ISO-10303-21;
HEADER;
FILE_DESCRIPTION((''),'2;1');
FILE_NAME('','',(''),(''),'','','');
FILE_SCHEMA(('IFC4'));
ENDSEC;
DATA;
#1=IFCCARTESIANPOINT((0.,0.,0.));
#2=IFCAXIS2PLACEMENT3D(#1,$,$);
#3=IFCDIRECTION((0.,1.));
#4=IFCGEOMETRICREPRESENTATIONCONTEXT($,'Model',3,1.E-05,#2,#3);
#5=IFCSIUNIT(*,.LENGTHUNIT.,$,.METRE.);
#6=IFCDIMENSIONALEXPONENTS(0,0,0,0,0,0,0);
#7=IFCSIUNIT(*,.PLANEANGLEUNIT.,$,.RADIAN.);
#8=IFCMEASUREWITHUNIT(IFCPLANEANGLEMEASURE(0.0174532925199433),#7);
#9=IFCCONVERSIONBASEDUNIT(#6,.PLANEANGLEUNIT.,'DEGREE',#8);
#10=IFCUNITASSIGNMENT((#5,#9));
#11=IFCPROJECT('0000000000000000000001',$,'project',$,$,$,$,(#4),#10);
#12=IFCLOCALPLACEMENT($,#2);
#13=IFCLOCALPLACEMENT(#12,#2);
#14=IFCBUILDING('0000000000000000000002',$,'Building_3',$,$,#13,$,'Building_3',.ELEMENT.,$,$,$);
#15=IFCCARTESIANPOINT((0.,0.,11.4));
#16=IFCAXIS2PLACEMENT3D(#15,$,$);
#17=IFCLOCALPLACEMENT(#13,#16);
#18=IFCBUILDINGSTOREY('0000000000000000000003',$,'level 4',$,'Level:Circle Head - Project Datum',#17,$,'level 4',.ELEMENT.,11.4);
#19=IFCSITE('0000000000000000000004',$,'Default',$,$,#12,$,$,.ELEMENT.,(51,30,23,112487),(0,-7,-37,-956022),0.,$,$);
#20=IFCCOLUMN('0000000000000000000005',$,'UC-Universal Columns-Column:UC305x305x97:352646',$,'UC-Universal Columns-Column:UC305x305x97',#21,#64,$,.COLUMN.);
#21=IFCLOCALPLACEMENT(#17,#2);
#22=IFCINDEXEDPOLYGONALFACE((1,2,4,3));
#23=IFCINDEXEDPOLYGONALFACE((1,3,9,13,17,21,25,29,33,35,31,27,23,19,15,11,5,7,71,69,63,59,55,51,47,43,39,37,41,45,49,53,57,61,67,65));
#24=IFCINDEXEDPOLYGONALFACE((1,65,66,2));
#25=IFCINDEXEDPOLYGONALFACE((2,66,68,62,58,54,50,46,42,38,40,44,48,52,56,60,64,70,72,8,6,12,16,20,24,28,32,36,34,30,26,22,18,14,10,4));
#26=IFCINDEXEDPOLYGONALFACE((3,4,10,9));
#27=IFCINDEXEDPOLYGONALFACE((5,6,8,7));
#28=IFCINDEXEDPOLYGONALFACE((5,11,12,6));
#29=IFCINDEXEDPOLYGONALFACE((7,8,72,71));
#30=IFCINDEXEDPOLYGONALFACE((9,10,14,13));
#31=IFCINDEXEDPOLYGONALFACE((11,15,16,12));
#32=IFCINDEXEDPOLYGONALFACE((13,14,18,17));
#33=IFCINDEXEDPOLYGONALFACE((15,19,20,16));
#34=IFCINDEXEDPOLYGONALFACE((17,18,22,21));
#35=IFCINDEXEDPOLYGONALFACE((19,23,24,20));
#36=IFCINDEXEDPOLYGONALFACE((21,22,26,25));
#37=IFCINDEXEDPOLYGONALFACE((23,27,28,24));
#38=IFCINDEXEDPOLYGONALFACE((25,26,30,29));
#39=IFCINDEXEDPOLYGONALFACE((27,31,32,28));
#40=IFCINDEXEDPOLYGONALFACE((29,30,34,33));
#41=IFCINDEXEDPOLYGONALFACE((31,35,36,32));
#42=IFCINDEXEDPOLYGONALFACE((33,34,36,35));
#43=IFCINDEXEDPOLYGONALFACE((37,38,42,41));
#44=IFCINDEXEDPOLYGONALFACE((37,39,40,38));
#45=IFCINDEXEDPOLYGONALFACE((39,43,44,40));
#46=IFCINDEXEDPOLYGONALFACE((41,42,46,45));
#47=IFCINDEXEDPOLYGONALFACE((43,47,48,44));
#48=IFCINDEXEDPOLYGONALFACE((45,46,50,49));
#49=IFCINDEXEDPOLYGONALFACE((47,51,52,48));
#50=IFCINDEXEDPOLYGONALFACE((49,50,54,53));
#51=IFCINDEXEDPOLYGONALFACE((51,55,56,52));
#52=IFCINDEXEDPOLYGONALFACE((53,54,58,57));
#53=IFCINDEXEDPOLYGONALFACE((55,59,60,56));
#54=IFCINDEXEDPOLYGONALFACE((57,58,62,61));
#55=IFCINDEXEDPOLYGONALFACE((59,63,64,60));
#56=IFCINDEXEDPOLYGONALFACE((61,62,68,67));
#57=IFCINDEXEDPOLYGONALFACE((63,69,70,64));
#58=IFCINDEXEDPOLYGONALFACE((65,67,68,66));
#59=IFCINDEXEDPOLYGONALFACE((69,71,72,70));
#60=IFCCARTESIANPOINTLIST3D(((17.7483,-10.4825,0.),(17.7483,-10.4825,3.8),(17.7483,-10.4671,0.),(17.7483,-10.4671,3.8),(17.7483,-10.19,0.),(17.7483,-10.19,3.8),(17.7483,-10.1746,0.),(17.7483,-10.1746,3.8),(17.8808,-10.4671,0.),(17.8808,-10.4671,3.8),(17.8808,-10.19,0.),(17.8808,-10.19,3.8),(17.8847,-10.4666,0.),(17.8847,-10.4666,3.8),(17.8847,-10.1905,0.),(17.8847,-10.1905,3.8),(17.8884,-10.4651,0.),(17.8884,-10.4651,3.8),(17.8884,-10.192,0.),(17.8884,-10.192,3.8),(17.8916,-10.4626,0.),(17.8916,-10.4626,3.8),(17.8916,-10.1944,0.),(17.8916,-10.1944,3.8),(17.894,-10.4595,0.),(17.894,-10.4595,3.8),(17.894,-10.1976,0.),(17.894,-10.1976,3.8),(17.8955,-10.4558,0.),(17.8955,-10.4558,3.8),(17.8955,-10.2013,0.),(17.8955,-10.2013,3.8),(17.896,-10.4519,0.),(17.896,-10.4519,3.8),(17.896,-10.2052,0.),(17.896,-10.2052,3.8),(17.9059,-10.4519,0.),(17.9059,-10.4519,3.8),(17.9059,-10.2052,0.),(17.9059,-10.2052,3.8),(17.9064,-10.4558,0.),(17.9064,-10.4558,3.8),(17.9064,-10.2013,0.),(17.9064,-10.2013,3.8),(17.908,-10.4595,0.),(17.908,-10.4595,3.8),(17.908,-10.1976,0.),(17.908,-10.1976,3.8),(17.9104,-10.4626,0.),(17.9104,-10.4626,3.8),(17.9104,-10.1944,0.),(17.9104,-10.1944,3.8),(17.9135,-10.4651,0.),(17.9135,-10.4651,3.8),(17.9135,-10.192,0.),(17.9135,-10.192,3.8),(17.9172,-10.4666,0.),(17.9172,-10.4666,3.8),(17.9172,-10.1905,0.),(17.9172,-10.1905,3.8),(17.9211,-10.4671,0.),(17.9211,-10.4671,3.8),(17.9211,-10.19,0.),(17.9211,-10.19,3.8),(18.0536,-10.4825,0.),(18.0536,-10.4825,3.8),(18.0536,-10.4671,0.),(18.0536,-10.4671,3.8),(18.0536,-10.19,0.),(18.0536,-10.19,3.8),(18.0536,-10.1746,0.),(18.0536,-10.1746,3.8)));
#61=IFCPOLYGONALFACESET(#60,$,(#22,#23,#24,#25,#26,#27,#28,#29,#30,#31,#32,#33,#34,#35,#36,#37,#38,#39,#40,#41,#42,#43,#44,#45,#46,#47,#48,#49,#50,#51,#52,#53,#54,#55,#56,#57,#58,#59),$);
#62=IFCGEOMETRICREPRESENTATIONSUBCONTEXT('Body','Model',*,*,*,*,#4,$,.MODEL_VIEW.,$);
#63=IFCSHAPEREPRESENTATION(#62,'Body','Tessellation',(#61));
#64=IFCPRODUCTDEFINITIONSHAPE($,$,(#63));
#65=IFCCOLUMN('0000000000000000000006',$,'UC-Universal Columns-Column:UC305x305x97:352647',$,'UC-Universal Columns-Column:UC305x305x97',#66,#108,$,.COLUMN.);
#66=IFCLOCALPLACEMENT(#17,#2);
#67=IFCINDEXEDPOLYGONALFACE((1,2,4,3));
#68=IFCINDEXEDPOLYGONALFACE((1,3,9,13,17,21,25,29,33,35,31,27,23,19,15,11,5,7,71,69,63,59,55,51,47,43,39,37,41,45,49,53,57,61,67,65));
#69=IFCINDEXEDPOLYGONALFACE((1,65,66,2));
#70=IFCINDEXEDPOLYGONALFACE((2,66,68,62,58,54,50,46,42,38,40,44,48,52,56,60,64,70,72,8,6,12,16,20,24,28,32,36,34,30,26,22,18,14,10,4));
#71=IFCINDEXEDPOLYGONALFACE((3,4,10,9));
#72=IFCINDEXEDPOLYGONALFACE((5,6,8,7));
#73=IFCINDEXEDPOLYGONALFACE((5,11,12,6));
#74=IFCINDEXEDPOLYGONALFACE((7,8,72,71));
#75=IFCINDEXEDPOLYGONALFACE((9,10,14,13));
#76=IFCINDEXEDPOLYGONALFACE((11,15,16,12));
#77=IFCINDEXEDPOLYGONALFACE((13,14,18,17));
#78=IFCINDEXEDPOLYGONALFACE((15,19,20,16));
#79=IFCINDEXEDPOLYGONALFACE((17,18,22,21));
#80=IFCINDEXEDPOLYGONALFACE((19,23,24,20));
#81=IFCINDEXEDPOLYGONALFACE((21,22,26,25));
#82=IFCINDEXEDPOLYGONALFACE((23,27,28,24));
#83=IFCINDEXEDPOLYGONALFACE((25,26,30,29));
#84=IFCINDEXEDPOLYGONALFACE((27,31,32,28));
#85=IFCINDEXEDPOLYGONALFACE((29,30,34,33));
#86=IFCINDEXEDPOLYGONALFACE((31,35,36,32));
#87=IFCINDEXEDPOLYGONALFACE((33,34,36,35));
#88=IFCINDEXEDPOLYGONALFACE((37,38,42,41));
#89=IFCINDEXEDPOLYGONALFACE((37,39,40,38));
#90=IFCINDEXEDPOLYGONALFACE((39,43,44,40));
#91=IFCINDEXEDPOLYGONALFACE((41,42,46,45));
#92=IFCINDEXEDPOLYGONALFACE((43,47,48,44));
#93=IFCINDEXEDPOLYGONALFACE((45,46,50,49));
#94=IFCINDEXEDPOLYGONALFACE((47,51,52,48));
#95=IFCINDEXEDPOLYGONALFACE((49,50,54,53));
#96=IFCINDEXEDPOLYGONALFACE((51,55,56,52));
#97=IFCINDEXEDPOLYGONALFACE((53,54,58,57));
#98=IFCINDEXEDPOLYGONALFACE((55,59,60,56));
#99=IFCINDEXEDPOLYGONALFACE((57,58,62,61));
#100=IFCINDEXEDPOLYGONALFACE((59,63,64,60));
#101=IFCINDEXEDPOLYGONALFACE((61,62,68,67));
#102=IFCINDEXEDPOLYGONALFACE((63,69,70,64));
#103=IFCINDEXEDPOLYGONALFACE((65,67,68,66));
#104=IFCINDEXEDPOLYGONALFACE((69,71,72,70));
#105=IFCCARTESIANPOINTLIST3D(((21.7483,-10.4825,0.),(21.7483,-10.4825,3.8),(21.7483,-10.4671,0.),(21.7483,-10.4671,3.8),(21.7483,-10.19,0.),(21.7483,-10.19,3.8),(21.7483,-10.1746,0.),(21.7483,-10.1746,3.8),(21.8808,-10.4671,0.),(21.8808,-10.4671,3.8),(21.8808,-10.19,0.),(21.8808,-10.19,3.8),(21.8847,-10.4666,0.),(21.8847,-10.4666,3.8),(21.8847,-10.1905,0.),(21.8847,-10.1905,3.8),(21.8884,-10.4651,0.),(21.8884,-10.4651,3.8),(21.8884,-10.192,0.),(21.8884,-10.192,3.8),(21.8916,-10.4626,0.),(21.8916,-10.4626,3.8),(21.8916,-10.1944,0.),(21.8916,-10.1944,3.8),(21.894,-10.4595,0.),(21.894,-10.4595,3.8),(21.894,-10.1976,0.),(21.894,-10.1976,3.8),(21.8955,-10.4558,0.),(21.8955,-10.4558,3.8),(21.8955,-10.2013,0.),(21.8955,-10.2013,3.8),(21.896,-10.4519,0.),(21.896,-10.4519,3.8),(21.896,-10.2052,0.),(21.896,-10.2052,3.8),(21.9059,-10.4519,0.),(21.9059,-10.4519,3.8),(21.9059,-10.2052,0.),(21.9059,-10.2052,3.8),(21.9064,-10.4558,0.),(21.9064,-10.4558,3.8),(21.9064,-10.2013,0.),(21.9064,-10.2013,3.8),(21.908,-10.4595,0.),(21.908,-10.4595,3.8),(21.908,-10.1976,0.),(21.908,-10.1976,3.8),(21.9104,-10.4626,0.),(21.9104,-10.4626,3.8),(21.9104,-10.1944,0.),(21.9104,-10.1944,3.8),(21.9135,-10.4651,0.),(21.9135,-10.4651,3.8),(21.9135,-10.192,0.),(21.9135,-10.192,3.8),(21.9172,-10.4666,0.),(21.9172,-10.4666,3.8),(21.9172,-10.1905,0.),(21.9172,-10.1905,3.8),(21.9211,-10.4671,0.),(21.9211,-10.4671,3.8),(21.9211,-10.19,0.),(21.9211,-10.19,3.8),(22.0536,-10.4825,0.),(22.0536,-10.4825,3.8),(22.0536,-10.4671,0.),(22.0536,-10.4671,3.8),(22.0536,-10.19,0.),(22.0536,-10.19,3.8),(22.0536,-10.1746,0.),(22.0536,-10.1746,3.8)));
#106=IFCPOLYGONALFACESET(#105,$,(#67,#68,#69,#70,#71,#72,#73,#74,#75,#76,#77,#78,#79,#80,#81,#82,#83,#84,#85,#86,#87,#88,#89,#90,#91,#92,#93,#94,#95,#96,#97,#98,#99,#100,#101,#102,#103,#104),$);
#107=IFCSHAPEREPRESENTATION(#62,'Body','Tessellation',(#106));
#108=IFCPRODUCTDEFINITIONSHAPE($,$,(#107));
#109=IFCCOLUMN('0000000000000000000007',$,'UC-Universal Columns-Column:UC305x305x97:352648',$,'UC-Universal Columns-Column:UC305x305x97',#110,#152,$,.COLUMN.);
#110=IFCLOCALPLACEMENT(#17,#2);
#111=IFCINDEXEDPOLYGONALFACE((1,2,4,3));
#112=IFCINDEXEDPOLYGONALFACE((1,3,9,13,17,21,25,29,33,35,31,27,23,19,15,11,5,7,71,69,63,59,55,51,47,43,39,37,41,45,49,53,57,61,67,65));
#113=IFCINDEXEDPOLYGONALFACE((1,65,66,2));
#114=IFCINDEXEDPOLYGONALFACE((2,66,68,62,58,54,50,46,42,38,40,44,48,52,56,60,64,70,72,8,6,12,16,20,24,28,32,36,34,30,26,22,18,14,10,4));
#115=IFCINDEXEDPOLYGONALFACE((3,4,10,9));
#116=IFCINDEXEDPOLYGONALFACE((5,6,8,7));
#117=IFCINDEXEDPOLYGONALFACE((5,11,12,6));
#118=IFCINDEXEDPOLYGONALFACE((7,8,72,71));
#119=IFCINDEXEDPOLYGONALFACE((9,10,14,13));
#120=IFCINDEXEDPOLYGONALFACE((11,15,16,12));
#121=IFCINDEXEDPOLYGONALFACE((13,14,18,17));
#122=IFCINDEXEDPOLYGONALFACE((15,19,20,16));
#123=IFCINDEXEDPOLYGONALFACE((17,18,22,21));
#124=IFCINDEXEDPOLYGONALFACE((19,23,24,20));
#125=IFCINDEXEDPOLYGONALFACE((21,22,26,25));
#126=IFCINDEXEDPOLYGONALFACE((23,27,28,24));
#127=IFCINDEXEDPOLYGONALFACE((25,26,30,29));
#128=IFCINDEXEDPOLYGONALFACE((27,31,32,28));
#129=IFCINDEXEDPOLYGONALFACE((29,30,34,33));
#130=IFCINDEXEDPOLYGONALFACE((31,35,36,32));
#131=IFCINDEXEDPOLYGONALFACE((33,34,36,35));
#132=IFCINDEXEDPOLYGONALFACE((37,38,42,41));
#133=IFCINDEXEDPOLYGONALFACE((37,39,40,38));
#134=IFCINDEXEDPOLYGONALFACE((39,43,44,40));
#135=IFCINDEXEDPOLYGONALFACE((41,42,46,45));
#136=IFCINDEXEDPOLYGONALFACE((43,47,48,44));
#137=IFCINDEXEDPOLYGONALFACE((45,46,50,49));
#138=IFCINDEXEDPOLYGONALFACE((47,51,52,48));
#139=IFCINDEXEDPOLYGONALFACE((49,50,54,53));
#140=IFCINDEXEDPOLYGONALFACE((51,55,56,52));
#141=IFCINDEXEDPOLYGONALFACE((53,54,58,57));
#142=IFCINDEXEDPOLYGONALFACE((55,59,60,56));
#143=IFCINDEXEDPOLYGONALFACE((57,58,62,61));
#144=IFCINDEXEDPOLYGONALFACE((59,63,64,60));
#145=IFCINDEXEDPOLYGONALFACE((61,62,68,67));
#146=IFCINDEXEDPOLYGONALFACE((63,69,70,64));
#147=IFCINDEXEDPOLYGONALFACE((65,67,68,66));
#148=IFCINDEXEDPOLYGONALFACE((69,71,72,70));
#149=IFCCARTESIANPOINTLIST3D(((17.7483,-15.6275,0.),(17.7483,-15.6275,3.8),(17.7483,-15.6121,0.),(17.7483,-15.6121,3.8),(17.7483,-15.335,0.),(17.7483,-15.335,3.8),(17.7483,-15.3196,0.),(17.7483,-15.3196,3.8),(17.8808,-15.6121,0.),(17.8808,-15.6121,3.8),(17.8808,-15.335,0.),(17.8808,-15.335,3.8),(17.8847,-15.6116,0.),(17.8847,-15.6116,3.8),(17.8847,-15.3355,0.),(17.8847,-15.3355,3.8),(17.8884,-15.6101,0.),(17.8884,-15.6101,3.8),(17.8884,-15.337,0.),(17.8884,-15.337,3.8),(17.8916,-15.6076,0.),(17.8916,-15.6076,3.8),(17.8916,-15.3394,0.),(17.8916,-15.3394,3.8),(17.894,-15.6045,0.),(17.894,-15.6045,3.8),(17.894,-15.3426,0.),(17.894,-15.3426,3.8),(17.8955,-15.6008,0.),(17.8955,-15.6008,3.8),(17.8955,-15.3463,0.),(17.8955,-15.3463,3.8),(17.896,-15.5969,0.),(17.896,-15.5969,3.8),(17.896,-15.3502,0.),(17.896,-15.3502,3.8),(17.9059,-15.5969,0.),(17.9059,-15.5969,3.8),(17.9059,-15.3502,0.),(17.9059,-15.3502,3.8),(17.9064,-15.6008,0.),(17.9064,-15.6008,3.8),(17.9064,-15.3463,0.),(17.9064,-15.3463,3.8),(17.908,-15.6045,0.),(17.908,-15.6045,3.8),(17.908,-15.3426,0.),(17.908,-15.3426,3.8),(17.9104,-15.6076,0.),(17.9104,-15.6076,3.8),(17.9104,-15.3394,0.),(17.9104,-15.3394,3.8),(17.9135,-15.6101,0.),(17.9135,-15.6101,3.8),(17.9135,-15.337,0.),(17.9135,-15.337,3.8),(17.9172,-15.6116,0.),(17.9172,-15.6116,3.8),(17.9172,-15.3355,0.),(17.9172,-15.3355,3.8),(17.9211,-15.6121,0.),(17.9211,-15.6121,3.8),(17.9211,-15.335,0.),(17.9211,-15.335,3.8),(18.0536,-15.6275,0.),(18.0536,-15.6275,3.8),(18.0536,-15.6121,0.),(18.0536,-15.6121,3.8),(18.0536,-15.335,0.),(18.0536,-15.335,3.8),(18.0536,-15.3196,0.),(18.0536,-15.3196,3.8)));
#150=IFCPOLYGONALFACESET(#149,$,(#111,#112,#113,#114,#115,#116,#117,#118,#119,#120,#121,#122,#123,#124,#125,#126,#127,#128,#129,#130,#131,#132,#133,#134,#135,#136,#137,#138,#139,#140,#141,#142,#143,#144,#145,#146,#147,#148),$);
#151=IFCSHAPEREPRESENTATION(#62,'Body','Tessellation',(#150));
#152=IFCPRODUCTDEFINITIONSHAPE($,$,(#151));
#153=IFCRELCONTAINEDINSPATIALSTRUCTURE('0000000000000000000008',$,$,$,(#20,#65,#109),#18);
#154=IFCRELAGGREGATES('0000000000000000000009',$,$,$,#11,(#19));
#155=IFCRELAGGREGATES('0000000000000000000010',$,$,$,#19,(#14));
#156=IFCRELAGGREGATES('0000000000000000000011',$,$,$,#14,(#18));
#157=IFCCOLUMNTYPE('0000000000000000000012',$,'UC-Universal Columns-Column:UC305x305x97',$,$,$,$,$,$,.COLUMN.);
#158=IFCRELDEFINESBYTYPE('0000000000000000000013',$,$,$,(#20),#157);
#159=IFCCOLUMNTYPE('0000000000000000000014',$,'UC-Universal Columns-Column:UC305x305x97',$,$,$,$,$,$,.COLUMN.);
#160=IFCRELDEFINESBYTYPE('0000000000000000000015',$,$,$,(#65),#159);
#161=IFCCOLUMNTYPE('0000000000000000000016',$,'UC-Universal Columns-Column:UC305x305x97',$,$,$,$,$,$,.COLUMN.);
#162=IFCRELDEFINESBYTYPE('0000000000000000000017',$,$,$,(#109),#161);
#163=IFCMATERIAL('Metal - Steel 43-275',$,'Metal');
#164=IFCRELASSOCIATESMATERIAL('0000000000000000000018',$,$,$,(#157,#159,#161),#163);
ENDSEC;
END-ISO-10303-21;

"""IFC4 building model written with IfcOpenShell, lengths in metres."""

from ifc_helpers import new_model, entity, si_unit, converted_unit, direction, frame, frame_2d, origin, place, context, subcontext, project, spatial, i_section, extrude, source, transform, mapped, material, material_profile, profile_set, type_object, type_shapes, element, save


model = new_model("IFC4")

# Units and contexts
model_context = context("Model", 3, precision=1e-05, world=origin(), true_north=direction((0.0, 1.0)))
body_context = subcontext(model_context, "Body", "Model", "MODEL_VIEW")
ifc_project = project(units=[si_unit("LENGTHUNIT", "METRE"), converted_unit("PLANEANGLEUNIT", "DEGREE", entity("IfcPlaneAngleMeasure", 0.0174532925199433), si_unit("PLANEANGLEUNIT", "RADIAN"), dimensions=[0, 0, 0, 0, 0, 0, 0])], contexts=[model_context])

# Site, building, storey
site_placement = place(None, origin())
site = spatial("IfcSite", under=ifc_project, at=site_placement, Name="Default", CompositionType="ELEMENT", RefLatitude=(51, 30, 23, 112487), RefLongitude=(0, -7, -37, -956022), RefElevation=0.0)
building_placement = place(site_placement, origin())
building = spatial("IfcBuilding", under=site, at=building_placement, Name="Building_3", LongName="Building_3", CompositionType="ELEMENT")
storey_placement = place(building_placement, frame((0.0, 0.0, 11.4)))
storey = spatial("IfcBuildingStorey", under=building, at=storey_placement, Name="level 4", ObjectType="Level:Circle Head - Project Datum", LongName="level 4", CompositionType="ELEMENT", Elevation=11.4)

# Columns
ifc_material_1 = material(Name="Metal - Steel 43-275", Category="Metal")
ifc_material_profile_1 = material_profile(ifc_material_1, i_section(OverallWidth=0.3053, OverallDepth=0.3079, WebThickness=0.0099, FlangeThickness=0.0154, FilletRadius=0.0152, at=frame_2d((0.0, 0.0), x_axis=(1.0, 0.0))), Name="UC305x305x97")
ifc_profile_set_1 = profile_set([ifc_material_profile_1], Name="UC305x305x97")
column_type_1 = type_object("IfcColumnType", Name="UC-Universal Columns-Column:UC305x305x97", PredefinedType="COLUMN", material=ifc_profile_set_1)
shared_shape_1 = source(origin(), body_context, "Body", "SweptSolid", [
    extrude(i_section(OverallWidth=0.3053, OverallDepth=0.3079, WebThickness=0.0099, FlangeThickness=0.0154, FilletRadius=0.0152, at=frame_2d((0.0, 0.0), x_axis=(1.0, 0.0))), frame((17.901, -10.3285, 11.4), z_axis=(0.0, 0.0, 1.0), x_axis=(-1.0, 0.0, 0.0)), (0.0, 0.0, 1.0), 3.8),
])
type_shapes(column_type_1, [shared_shape_1])
column_1_placement = place(storey_placement, frame((0.0, 0.0, -11.4)))
element("IfcColumn", 1, at=column_1_placement, inside=storey, type_object=column_type_1, Name="UC-Universal Columns-Column:UC305x305x97:352646", ObjectType="UC-Universal Columns-Column:UC305x305x97", PredefinedType="COLUMN", context=body_context, shape_type="MappedRepresentation", body=[
    mapped(shared_shape_1, transform((0.0, 0.0, 0.0), scale=1.0)),
])
column_type_2 = type_object("IfcColumnType", Name="UC-Universal Columns-Column:UC305x305x97", PredefinedType="COLUMN", material=ifc_profile_set_1)
shared_shape_2 = source(origin(), body_context, "Body", "SweptSolid", [
    extrude(i_section(OverallWidth=0.3053, OverallDepth=0.3079, WebThickness=0.0099, FlangeThickness=0.0154, FilletRadius=0.0152, at=frame_2d((0.0, 0.0), x_axis=(1.0, 0.0))), frame((21.901, -10.3285, 11.4), z_axis=(0.0, 0.0, 1.0), x_axis=(-1.0, 0.0, 0.0)), (0.0, 0.0, 1.0), 3.8),
])
type_shapes(column_type_2, [shared_shape_2])
column_2_placement = place(storey_placement, frame((0.0, 0.0, -11.4)))
element("IfcColumn", 2, at=column_2_placement, inside=storey, type_object=column_type_2, Name="UC-Universal Columns-Column:UC305x305x97:352647", ObjectType="UC-Universal Columns-Column:UC305x305x97", PredefinedType="COLUMN", context=body_context, shape_type="MappedRepresentation", body=[
    mapped(shared_shape_2, transform((0.0, 0.0, 0.0), scale=1.0)),
])
column_type_3 = type_object("IfcColumnType", Name="UC-Universal Columns-Column:UC305x305x97", PredefinedType="COLUMN", material=ifc_profile_set_1)
shared_shape_3 = source(origin(), body_context, "Body", "SweptSolid", [
    extrude(i_section(OverallWidth=0.3053, OverallDepth=0.3079, WebThickness=0.0099, FlangeThickness=0.0154, FilletRadius=0.0152, at=frame_2d((0.0, 0.0), x_axis=(1.0, 0.0))), frame((17.901, -15.4735, 11.4), z_axis=(0.0, 0.0, 1.0), x_axis=(-1.0, 0.0, 0.0)), (0.0, 0.0, 1.0), 3.8),
])
type_shapes(column_type_3, [shared_shape_3])
column_3_placement = place(storey_placement, frame((0.0, 0.0, -11.4)))
element("IfcColumn", 3, at=column_3_placement, inside=storey, type_object=column_type_3, Name="UC-Universal Columns-Column:UC305x305x97:352648", ObjectType="UC-Universal Columns-Column:UC305x305x97", PredefinedType="COLUMN", context=body_context, shape_type="MappedRepresentation", body=[
    mapped(shared_shape_3, transform((0.0, 0.0, 0.0), scale=1.0)),
])

save(model, "model.ifc")
